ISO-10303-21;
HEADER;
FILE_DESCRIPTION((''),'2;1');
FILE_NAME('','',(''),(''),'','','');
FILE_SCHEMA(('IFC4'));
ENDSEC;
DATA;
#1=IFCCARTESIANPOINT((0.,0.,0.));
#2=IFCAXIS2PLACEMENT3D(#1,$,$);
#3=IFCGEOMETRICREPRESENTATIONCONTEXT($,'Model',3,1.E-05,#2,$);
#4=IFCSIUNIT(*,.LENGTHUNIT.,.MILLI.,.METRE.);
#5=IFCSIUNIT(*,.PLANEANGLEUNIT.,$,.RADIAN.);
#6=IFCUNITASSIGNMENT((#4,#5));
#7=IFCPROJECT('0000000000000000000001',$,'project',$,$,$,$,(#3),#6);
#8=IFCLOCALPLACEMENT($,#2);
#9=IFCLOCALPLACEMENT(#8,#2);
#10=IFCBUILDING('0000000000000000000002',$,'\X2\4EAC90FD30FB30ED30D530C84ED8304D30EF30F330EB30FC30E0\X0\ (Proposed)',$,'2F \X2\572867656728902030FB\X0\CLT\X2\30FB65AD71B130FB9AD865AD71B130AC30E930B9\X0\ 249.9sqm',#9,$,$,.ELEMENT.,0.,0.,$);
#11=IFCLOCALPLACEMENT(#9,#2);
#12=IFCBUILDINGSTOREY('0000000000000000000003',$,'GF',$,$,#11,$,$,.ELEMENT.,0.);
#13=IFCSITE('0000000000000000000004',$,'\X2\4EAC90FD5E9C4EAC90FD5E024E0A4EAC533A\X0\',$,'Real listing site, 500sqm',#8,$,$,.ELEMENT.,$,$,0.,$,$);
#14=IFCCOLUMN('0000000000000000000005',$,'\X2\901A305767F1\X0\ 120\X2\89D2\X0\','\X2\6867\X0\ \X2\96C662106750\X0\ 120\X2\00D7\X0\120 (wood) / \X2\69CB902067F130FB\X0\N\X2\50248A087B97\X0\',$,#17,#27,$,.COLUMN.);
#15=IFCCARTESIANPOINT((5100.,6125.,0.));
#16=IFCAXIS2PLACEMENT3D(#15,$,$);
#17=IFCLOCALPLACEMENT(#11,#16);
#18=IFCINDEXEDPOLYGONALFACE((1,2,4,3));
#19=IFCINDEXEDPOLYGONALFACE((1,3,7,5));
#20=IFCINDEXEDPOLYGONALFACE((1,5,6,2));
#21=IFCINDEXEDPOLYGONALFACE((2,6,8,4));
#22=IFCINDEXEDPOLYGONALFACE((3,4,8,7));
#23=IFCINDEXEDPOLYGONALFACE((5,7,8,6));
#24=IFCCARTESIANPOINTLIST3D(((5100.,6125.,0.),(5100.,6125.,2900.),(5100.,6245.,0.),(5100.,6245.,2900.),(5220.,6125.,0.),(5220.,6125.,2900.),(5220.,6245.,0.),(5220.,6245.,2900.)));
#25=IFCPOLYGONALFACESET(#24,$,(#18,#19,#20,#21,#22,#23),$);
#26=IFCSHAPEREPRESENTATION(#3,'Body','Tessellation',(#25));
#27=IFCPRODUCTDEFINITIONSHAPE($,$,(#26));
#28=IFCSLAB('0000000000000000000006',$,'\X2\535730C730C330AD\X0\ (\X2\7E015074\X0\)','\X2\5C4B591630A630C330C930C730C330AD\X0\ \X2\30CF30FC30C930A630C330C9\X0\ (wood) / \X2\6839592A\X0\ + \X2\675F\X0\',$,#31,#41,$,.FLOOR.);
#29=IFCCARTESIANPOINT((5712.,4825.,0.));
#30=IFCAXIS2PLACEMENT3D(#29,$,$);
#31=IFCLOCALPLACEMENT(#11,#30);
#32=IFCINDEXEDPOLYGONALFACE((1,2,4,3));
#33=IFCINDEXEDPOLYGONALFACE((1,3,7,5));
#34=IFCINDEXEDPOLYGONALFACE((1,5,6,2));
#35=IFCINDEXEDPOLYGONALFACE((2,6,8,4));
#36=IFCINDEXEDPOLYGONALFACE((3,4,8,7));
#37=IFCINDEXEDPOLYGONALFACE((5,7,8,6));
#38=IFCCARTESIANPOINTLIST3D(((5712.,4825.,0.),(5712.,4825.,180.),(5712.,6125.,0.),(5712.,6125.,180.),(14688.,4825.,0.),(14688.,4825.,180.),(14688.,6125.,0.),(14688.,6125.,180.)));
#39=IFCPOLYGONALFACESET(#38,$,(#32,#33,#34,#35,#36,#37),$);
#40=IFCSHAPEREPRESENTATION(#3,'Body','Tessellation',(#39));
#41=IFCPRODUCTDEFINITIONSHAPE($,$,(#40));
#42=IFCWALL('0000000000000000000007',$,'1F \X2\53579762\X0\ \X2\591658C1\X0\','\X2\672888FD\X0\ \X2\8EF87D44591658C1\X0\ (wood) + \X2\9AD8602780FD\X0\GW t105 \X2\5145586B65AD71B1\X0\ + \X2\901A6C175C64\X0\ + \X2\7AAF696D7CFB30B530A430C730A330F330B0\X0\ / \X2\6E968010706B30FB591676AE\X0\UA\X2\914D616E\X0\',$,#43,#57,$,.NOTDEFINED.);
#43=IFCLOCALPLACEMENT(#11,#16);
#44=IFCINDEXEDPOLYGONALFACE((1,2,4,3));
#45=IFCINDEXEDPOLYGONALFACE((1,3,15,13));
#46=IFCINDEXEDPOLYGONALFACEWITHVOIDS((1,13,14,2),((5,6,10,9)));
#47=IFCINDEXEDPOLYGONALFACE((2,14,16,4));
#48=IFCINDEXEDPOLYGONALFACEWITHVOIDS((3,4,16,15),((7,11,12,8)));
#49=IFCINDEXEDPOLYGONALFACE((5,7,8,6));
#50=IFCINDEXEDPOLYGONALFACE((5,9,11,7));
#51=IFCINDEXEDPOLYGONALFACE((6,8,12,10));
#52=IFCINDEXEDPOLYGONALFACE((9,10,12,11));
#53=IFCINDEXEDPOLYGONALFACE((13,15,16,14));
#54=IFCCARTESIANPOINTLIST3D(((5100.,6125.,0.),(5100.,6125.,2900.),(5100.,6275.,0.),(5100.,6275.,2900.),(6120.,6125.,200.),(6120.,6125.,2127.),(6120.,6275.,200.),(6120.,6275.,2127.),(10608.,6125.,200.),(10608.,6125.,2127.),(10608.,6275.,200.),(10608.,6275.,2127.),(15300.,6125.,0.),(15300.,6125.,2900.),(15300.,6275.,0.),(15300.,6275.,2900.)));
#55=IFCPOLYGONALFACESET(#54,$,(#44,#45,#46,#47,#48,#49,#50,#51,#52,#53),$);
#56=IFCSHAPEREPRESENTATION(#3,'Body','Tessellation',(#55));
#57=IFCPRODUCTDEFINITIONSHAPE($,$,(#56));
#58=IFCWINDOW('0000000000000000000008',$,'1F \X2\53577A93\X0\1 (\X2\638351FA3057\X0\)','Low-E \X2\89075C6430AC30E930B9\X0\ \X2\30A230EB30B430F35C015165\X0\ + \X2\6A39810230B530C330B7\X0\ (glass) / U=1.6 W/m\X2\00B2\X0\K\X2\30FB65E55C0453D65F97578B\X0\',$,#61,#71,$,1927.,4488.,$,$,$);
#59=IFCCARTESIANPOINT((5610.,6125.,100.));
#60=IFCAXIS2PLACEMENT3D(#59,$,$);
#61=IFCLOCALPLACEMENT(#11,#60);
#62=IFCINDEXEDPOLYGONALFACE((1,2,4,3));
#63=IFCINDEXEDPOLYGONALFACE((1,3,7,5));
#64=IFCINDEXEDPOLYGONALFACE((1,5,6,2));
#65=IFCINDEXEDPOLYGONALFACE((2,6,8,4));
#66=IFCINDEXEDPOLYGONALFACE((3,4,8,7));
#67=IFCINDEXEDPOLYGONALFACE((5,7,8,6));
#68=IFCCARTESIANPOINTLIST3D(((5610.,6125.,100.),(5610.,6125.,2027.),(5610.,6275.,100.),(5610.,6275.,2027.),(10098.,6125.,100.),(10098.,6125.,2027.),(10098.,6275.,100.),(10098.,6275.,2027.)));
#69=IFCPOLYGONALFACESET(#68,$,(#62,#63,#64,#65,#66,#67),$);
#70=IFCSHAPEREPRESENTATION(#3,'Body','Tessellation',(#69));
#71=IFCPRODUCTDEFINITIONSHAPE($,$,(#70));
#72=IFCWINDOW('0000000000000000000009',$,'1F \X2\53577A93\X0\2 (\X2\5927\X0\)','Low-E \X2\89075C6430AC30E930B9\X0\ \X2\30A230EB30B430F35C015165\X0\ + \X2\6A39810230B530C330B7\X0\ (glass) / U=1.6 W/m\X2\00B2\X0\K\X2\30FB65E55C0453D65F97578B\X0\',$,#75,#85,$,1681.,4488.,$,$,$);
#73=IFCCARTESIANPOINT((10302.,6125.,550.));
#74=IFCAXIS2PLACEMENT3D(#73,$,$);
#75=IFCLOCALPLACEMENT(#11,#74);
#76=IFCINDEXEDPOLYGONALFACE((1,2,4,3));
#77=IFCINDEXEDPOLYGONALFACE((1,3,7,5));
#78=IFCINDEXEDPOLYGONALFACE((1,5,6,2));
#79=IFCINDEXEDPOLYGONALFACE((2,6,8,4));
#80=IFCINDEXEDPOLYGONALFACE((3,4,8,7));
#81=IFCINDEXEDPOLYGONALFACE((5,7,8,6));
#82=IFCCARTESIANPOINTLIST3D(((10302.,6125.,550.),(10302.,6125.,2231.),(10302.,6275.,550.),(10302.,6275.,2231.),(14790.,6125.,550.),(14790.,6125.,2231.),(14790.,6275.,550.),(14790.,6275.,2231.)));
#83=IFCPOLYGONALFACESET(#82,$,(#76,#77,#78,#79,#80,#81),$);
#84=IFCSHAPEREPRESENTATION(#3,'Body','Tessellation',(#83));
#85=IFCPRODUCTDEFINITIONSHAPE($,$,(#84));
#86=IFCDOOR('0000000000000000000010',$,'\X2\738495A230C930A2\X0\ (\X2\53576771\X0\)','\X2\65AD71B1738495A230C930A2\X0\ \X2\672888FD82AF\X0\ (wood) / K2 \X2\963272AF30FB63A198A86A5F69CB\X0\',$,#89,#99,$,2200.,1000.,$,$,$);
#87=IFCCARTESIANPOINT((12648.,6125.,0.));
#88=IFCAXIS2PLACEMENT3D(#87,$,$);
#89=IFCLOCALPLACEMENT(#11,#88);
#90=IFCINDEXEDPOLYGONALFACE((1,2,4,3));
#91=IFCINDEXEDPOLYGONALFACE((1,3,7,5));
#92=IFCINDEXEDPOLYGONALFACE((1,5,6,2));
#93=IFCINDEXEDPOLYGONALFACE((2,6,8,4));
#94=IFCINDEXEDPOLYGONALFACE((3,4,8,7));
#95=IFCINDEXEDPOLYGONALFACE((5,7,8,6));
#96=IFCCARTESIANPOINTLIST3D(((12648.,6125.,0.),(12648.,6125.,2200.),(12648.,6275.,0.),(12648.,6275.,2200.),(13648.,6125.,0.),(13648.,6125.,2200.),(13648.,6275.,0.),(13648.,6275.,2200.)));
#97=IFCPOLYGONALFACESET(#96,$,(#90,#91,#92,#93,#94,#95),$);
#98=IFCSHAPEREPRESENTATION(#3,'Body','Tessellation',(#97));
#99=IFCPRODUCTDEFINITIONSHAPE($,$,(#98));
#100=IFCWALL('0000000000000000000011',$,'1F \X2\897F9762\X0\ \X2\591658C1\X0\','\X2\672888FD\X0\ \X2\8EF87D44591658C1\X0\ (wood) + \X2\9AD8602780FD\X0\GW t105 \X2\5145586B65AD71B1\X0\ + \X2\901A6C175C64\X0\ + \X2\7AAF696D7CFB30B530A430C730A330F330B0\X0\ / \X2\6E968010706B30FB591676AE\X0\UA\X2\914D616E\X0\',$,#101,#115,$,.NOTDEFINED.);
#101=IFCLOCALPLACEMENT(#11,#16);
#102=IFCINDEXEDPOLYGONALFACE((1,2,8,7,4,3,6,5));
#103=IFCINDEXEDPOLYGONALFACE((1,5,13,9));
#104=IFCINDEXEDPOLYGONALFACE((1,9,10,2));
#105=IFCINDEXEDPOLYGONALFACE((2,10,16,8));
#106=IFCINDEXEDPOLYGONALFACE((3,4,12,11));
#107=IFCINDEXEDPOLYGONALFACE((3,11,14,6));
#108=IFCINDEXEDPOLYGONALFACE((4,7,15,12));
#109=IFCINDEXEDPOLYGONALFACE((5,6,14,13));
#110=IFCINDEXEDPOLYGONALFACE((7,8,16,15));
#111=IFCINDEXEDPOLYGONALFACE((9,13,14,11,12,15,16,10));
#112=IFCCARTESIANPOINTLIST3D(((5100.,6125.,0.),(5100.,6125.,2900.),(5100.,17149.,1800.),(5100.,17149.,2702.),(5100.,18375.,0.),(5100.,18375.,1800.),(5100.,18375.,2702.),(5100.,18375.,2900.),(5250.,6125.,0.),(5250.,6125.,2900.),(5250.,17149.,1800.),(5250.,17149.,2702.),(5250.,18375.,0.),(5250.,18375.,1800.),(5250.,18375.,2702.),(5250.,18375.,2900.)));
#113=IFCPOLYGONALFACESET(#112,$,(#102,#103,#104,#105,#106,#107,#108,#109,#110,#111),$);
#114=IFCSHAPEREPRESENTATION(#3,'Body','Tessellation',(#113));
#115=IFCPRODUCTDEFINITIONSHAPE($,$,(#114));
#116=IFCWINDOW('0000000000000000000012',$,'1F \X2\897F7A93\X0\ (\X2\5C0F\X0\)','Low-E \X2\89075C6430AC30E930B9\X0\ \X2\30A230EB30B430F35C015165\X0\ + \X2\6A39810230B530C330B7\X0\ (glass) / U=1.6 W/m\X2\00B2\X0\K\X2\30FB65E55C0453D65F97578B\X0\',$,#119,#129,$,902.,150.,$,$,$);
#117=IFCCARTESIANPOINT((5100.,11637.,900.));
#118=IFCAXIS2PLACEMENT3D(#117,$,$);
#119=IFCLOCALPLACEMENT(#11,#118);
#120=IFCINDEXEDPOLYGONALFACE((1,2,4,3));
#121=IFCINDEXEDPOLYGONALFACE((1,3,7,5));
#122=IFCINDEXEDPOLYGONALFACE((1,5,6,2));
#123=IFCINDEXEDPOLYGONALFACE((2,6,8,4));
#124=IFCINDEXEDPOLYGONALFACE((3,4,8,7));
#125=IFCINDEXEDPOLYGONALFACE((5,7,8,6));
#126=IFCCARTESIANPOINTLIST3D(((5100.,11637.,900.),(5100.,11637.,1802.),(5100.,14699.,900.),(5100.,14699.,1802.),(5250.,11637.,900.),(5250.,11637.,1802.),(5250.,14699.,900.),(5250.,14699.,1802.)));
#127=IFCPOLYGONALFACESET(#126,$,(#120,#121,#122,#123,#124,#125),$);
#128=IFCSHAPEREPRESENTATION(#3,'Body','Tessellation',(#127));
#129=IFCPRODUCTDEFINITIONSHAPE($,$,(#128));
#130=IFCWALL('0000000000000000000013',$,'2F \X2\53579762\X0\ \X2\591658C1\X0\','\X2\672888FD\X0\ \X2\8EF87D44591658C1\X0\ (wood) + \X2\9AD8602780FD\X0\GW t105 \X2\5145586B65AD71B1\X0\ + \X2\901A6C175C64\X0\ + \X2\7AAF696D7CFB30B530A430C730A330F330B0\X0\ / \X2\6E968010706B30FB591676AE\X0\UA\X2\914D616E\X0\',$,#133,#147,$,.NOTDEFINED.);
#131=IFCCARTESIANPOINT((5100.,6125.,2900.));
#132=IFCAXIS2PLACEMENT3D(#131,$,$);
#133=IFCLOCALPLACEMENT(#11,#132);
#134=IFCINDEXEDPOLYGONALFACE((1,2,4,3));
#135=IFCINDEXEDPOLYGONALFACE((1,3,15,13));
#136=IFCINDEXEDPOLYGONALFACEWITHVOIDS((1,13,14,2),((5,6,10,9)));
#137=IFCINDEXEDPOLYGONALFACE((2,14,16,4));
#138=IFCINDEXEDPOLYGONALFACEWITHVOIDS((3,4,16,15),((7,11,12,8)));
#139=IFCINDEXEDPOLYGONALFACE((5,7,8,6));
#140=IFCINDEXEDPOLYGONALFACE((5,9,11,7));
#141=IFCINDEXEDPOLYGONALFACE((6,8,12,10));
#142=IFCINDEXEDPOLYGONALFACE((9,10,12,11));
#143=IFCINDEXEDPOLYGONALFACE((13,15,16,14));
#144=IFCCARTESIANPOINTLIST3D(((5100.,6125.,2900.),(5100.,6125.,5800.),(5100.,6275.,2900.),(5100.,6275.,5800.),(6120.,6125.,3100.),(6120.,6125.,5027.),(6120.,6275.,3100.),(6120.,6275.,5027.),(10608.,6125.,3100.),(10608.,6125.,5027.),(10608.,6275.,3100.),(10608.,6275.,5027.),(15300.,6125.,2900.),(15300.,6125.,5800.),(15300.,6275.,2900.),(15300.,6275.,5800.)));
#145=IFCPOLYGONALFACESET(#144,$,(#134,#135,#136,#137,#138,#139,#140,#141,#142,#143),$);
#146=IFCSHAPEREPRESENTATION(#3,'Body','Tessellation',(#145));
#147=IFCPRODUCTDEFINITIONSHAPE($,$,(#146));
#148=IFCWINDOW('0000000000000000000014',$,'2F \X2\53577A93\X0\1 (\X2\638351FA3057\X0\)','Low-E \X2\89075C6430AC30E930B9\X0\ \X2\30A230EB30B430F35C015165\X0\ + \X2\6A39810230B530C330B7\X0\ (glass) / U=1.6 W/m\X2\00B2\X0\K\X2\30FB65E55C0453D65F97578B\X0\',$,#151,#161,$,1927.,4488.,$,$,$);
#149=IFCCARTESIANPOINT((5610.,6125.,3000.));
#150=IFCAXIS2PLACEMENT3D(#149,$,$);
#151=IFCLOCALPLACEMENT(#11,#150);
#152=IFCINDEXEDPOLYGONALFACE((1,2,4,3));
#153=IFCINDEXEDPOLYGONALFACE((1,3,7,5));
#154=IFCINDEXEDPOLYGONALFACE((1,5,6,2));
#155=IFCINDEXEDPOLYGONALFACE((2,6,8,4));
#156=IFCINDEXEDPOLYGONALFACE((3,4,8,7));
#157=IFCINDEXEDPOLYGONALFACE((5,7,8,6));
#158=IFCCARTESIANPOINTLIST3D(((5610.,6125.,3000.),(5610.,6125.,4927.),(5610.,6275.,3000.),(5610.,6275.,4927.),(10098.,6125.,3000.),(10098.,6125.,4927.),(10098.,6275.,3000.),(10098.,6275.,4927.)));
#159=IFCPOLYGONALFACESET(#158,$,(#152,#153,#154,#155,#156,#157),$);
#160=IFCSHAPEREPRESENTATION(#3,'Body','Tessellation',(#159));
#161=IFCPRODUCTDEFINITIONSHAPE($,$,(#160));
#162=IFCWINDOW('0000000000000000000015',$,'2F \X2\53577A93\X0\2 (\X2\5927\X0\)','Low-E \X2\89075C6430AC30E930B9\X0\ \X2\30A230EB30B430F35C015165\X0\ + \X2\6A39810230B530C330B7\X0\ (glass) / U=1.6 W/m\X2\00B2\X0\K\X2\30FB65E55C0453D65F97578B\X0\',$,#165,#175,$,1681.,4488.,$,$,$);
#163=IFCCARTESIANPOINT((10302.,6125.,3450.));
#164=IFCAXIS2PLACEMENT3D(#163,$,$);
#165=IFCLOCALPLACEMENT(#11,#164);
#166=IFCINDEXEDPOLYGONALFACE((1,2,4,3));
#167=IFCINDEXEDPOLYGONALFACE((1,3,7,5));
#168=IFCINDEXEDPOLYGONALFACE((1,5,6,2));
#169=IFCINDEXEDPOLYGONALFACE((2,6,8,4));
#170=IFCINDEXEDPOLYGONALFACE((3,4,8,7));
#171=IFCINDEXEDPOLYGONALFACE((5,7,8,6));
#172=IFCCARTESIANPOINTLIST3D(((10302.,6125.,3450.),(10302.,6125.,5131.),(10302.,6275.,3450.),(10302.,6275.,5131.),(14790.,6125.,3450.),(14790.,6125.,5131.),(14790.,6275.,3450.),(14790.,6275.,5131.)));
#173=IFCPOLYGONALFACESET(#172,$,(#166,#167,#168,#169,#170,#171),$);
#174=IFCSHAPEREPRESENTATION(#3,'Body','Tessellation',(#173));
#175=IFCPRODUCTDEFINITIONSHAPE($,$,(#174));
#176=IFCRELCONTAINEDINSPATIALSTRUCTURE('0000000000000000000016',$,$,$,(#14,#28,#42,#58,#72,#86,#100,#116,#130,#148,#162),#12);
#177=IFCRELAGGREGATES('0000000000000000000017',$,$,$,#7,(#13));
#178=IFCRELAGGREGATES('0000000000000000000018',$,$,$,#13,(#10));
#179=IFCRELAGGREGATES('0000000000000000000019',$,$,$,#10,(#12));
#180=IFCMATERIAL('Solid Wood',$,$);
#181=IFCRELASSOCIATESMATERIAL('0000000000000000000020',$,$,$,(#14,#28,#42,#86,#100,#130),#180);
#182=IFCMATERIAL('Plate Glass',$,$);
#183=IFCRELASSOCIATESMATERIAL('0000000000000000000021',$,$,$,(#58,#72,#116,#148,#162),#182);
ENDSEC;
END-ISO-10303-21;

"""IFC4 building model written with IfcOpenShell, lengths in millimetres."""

from ifc_helpers import new_model, si_unit, frame, frame_2d, origin, place, context, project, spatial, rectangle, extrude, material, element, fill, save


model = new_model("IFC4")

# Units and contexts
model_context = context("Model", 3, precision=1e-05, world=origin())
ifc_project = project(units=[si_unit("LENGTHUNIT", "METRE", prefix="MILLI"), si_unit("PLANEANGLEUNIT", "RADIAN")], contexts=[model_context])

# Site, building, storey
site_placement = place(None, origin())
site = spatial("IfcSite", under=ifc_project, at=site_placement, Name="京都府京都市上京区", ObjectType="Real listing site, 500sqm", CompositionType="ELEMENT", RefElevation=0.0)
building_placement = place(site_placement, origin())
building = spatial("IfcBuilding", under=site, at=building_placement, Name="京都・ロフト付きワンルーム (Proposed)", ObjectType="2F 在来木造・CLT・断熱・高断熱ガラス 249.9sqm", CompositionType="ELEMENT", ElevationOfRefHeight=0.0, ElevationOfTerrain=0.0)
storey_placement = place(building_placement, origin())
storey = spatial("IfcBuildingStorey", under=building, at=storey_placement, Name="GF", CompositionType="ELEMENT", Elevation=0.0)

# Column
ifc_material_1 = material(Name="Solid Wood")
column_placement = place(storey_placement, frame((5100.0, 6125.0, 0.0)))
element("IfcColumn", 1, at=column_placement, inside=storey, material=ifc_material_1, Name="通し柱 120角", Description="桧 集成材 120×120 (wood) / 構造柱・N値計算", PredefinedType="COLUMN", context=model_context, shape_type="SweptSolid", body=[
    extrude(rectangle(XDim=120.0, YDim=120.0, at=frame_2d((60.0, 60.0))), frame((5100.0, 6125.0, 0.0)), (0.0, 0.0, 1.0), 2900.0),
])

# Slab
slab_1_placement = place(storey_placement, frame((5712.0, 4825.0, 0.0)))
element("IfcSlab", 2, at=slab_1_placement, inside=storey, material=ifc_material_1, Name="南デッキ (縁側)", Description="屋外ウッドデッキ ハードウッド (wood) / 根太 + 束", PredefinedType="FLOOR", context=model_context, shape_type="SweptSolid", body=[
    extrude(rectangle(XDim=8976.0, YDim=1300.0, at=frame_2d((4488.0, 650.0))), frame((5712.0, 4825.0, 0.0)), (0.0, 0.0, 1.0), 180.0),
])

# Wall, openings, windows, door
wall_1_placement = place(storey_placement, frame((5100.0, 6125.0, 0.0)))
wall_1 = element("IfcWall", 3, at=wall_1_placement, inside=storey, material=ifc_material_1, Name="1F 南面 外壁", Description="木製 軸組外壁 (wood) + 高性能GW t105 充填断熱 + 通気層 + 窯業系サイディング / 準耐火・外皮UA配慮", PredefinedType="NOTDEFINED", context=model_context, shape_type="SweptSolid", body=[
    extrude(rectangle(XDim=10200.0, YDim=150.0, at=frame_2d((5100.0, 75.0))), frame((5100.0, 6125.0, 0.0)), (0.0, 0.0, 1.0), 2900.0),
])
opening_1_placement = place(storey_placement, frame((5610.0, 6125.0, 100.0)))
opening_1 = element("IfcOpeningElement", 4, at=opening_1_placement, cuts=wall_1, PredefinedType="NOTDEFINED", context=model_context, shape_type="SweptSolid", body=[
    extrude(rectangle(XDim=4488.0, YDim=150.0, at=frame_2d((2244.0, 75.0))), frame((5610.0, 6125.0, 100.0)), (0.0, 0.0, 1.0), 1927.0),
])
opening_2_placement = place(storey_placement, frame((10302.0, 6125.0, 550.0)))
opening_2 = element("IfcOpeningElement", 5, at=opening_2_placement, cuts=wall_1, PredefinedType="NOTDEFINED", context=model_context, shape_type="SweptSolid", body=[
    extrude(rectangle(XDim=4488.0, YDim=150.0, at=frame_2d((2244.0, 75.0))), frame((10302.0, 6125.0, 550.0)), (0.0, 0.0, 1.0), 1681.0),
])
opening_3_placement = place(storey_placement, frame((12648.0, 6125.0, 0.0)))
opening_3 = element("IfcOpeningElement", 6, at=opening_3_placement, cuts=wall_1, PredefinedType="NOTDEFINED", context=model_context, shape_type="SweptSolid", body=[
    extrude(rectangle(XDim=1000.0, YDim=150.0, at=frame_2d((500.0, 75.0))), frame((12648.0, 6125.0, 0.0)), (0.0, 0.0, 1.0), 2200.0),
])
ifc_material_2 = material(Name="Plate Glass")
window_1_placement = place(storey_placement, frame((5610.0, 6125.0, 100.0)))
window_1 = element("IfcWindow", 7, at=window_1_placement, inside=storey, material=ifc_material_2, Name="1F 南窓1 (掃出し)", Description="Low-E 複層ガラス アルゴン封入 + 樹脂サッシ (glass) / U=1.6 W/m²K・日射取得型", OverallHeight=1927.0, OverallWidth=4488.0, context=model_context, shape_type="SweptSolid", body=[
    extrude(rectangle(XDim=4488.0, YDim=150.0, at=frame_2d((2244.0, 75.0))), frame((5610.0, 6125.0, 100.0)), (0.0, 0.0, 1.0), 1927.0),
])
fill(opening_1, window_1)
window_2_placement = place(storey_placement, frame((10302.0, 6125.0, 550.0)))
window_2 = element("IfcWindow", 8, at=window_2_placement, inside=storey, material=ifc_material_2, Name="1F 南窓2 (大)", Description="Low-E 複層ガラス アルゴン封入 + 樹脂サッシ (glass) / U=1.6 W/m²K・日射取得型", OverallHeight=1681.0, OverallWidth=4488.0, context=model_context, shape_type="SweptSolid", body=[
    extrude(rectangle(XDim=4488.0, YDim=150.0, at=frame_2d((2244.0, 75.0))), frame((10302.0, 6125.0, 550.0)), (0.0, 0.0, 1.0), 1681.0),
])
fill(opening_2, window_2)
door_placement = place(storey_placement, frame((12648.0, 6125.0, 0.0)))
door = element("IfcDoor", 9, at=door_placement, inside=storey, material=ifc_material_1, Name="玄関ドア (南東)", Description="断熱玄関ドア 木製芯 (wood) / K2 防犯・採風機構", OverallHeight=2200.0, OverallWidth=1000.0, context=model_context, shape_type="SweptSolid", body=[
    extrude(rectangle(XDim=1000.0, YDim=150.0, at=frame_2d((500.0, 75.0))), frame((12648.0, 6125.0, 0.0)), (0.0, 0.0, 1.0), 2200.0),
])
fill(opening_3, door)

# Wall, opening, window
wall_2_placement = place(storey_placement, frame((5100.0, 6125.0, 0.0)))
wall_2 = element("IfcWall", 10, at=wall_2_placement, inside=storey, material=ifc_material_1, Name="1F 西面 外壁", Description="木製 軸組外壁 (wood) + 高性能GW t105 充填断熱 + 通気層 + 窯業系サイディング / 準耐火・外皮UA配慮", PredefinedType="NOTDEFINED", context=model_context, shape_type="SweptSolid", body=[
    extrude(rectangle(XDim=150.0, YDim=12250.0, at=frame_2d((75.0, 6125.0))), frame((5100.0, 6125.0, 0.0)), (0.0, 0.0, 1.0), 2900.0),
])
opening_4_placement = place(storey_placement, frame((5100.0, 11637.0, 900.0)))
opening_4 = element("IfcOpeningElement", 11, at=opening_4_placement, cuts=wall_2, PredefinedType="NOTDEFINED", context=model_context, shape_type="SweptSolid", body=[
    extrude(rectangle(XDim=150.0, YDim=3062.0, at=frame_2d((75.0, 1531.0))), frame((5100.0, 11637.0, 900.0)), (0.0, 0.0, 1.0), 902.0),
])
window_3_placement = place(storey_placement, frame((5100.0, 11637.0, 900.0)))
window_3 = element("IfcWindow", 12, at=window_3_placement, inside=storey, material=ifc_material_2, Name="1F 西窓 (小)", Description="Low-E 複層ガラス アルゴン封入 + 樹脂サッシ (glass) / U=1.6 W/m²K・日射取得型", OverallHeight=902.0, OverallWidth=150.0, context=model_context, shape_type="SweptSolid", body=[
    extrude(rectangle(XDim=150.0, YDim=3062.0, at=frame_2d((75.0, 1531.0))), frame((5100.0, 11637.0, 900.0)), (0.0, 0.0, 1.0), 902.0),
])
fill(opening_4, window_3)

# Wall, openings, windows
wall_3_placement = place(storey_placement, frame((5100.0, 6125.0, 2900.0)))
wall_3 = element("IfcWall", 13, at=wall_3_placement, inside=storey, material=ifc_material_1, Name="2F 南面 外壁", Description="木製 軸組外壁 (wood) + 高性能GW t105 充填断熱 + 通気層 + 窯業系サイディング / 準耐火・外皮UA配慮", PredefinedType="NOTDEFINED", context=model_context, shape_type="SweptSolid", body=[
    extrude(rectangle(XDim=10200.0, YDim=150.0, at=frame_2d((5100.0, 75.0))), frame((5100.0, 6125.0, 2900.0)), (0.0, 0.0, 1.0), 2900.0),
])
opening_5_placement = place(storey_placement, frame((5610.0, 6125.0, 3000.0)))
opening_5 = element("IfcOpeningElement", 14, at=opening_5_placement, cuts=wall_3, PredefinedType="NOTDEFINED", context=model_context, shape_type="SweptSolid", body=[
    extrude(rectangle(XDim=4488.0, YDim=150.0, at=frame_2d((2244.0, 75.0))), frame((5610.0, 6125.0, 3000.0)), (0.0, 0.0, 1.0), 1927.0),
])
opening_6_placement = place(storey_placement, frame((10302.0, 6125.0, 3450.0)))
opening_6 = element("IfcOpeningElement", 15, at=opening_6_placement, cuts=wall_3, PredefinedType="NOTDEFINED", context=model_context, shape_type="SweptSolid", body=[
    extrude(rectangle(XDim=4488.0, YDim=150.0, at=frame_2d((2244.0, 75.0))), frame((10302.0, 6125.0, 3450.0)), (0.0, 0.0, 1.0), 1681.0),
])
window_4_placement = place(storey_placement, frame((5610.0, 6125.0, 3000.0)))
window_4 = element("IfcWindow", 16, at=window_4_placement, inside=storey, material=ifc_material_2, Name="2F 南窓1 (掃出し)", Description="Low-E 複層ガラス アルゴン封入 + 樹脂サッシ (glass) / U=1.6 W/m²K・日射取得型", OverallHeight=1927.0, OverallWidth=4488.0, context=model_context, shape_type="SweptSolid", body=[
    extrude(rectangle(XDim=4488.0, YDim=150.0, at=frame_2d((2244.0, 75.0))), frame((5610.0, 6125.0, 3000.0)), (0.0, 0.0, 1.0), 1927.0),
])
fill(opening_5, window_4)
window_5_placement = place(storey_placement, frame((10302.0, 6125.0, 3450.0)))
window_5 = element("IfcWindow", 17, at=window_5_placement, inside=storey, material=ifc_material_2, Name="2F 南窓2 (大)", Description="Low-E 複層ガラス アルゴン封入 + 樹脂サッシ (glass) / U=1.6 W/m²K・日射取得型", OverallHeight=1681.0, OverallWidth=4488.0, context=model_context, shape_type="SweptSolid", body=[
    extrude(rectangle(XDim=4488.0, YDim=150.0, at=frame_2d((2244.0, 75.0))), frame((10302.0, 6125.0, 3450.0)), (0.0, 0.0, 1.0), 1681.0),
])
fill(opening_6, window_5)

save(model, "model.ifc")
